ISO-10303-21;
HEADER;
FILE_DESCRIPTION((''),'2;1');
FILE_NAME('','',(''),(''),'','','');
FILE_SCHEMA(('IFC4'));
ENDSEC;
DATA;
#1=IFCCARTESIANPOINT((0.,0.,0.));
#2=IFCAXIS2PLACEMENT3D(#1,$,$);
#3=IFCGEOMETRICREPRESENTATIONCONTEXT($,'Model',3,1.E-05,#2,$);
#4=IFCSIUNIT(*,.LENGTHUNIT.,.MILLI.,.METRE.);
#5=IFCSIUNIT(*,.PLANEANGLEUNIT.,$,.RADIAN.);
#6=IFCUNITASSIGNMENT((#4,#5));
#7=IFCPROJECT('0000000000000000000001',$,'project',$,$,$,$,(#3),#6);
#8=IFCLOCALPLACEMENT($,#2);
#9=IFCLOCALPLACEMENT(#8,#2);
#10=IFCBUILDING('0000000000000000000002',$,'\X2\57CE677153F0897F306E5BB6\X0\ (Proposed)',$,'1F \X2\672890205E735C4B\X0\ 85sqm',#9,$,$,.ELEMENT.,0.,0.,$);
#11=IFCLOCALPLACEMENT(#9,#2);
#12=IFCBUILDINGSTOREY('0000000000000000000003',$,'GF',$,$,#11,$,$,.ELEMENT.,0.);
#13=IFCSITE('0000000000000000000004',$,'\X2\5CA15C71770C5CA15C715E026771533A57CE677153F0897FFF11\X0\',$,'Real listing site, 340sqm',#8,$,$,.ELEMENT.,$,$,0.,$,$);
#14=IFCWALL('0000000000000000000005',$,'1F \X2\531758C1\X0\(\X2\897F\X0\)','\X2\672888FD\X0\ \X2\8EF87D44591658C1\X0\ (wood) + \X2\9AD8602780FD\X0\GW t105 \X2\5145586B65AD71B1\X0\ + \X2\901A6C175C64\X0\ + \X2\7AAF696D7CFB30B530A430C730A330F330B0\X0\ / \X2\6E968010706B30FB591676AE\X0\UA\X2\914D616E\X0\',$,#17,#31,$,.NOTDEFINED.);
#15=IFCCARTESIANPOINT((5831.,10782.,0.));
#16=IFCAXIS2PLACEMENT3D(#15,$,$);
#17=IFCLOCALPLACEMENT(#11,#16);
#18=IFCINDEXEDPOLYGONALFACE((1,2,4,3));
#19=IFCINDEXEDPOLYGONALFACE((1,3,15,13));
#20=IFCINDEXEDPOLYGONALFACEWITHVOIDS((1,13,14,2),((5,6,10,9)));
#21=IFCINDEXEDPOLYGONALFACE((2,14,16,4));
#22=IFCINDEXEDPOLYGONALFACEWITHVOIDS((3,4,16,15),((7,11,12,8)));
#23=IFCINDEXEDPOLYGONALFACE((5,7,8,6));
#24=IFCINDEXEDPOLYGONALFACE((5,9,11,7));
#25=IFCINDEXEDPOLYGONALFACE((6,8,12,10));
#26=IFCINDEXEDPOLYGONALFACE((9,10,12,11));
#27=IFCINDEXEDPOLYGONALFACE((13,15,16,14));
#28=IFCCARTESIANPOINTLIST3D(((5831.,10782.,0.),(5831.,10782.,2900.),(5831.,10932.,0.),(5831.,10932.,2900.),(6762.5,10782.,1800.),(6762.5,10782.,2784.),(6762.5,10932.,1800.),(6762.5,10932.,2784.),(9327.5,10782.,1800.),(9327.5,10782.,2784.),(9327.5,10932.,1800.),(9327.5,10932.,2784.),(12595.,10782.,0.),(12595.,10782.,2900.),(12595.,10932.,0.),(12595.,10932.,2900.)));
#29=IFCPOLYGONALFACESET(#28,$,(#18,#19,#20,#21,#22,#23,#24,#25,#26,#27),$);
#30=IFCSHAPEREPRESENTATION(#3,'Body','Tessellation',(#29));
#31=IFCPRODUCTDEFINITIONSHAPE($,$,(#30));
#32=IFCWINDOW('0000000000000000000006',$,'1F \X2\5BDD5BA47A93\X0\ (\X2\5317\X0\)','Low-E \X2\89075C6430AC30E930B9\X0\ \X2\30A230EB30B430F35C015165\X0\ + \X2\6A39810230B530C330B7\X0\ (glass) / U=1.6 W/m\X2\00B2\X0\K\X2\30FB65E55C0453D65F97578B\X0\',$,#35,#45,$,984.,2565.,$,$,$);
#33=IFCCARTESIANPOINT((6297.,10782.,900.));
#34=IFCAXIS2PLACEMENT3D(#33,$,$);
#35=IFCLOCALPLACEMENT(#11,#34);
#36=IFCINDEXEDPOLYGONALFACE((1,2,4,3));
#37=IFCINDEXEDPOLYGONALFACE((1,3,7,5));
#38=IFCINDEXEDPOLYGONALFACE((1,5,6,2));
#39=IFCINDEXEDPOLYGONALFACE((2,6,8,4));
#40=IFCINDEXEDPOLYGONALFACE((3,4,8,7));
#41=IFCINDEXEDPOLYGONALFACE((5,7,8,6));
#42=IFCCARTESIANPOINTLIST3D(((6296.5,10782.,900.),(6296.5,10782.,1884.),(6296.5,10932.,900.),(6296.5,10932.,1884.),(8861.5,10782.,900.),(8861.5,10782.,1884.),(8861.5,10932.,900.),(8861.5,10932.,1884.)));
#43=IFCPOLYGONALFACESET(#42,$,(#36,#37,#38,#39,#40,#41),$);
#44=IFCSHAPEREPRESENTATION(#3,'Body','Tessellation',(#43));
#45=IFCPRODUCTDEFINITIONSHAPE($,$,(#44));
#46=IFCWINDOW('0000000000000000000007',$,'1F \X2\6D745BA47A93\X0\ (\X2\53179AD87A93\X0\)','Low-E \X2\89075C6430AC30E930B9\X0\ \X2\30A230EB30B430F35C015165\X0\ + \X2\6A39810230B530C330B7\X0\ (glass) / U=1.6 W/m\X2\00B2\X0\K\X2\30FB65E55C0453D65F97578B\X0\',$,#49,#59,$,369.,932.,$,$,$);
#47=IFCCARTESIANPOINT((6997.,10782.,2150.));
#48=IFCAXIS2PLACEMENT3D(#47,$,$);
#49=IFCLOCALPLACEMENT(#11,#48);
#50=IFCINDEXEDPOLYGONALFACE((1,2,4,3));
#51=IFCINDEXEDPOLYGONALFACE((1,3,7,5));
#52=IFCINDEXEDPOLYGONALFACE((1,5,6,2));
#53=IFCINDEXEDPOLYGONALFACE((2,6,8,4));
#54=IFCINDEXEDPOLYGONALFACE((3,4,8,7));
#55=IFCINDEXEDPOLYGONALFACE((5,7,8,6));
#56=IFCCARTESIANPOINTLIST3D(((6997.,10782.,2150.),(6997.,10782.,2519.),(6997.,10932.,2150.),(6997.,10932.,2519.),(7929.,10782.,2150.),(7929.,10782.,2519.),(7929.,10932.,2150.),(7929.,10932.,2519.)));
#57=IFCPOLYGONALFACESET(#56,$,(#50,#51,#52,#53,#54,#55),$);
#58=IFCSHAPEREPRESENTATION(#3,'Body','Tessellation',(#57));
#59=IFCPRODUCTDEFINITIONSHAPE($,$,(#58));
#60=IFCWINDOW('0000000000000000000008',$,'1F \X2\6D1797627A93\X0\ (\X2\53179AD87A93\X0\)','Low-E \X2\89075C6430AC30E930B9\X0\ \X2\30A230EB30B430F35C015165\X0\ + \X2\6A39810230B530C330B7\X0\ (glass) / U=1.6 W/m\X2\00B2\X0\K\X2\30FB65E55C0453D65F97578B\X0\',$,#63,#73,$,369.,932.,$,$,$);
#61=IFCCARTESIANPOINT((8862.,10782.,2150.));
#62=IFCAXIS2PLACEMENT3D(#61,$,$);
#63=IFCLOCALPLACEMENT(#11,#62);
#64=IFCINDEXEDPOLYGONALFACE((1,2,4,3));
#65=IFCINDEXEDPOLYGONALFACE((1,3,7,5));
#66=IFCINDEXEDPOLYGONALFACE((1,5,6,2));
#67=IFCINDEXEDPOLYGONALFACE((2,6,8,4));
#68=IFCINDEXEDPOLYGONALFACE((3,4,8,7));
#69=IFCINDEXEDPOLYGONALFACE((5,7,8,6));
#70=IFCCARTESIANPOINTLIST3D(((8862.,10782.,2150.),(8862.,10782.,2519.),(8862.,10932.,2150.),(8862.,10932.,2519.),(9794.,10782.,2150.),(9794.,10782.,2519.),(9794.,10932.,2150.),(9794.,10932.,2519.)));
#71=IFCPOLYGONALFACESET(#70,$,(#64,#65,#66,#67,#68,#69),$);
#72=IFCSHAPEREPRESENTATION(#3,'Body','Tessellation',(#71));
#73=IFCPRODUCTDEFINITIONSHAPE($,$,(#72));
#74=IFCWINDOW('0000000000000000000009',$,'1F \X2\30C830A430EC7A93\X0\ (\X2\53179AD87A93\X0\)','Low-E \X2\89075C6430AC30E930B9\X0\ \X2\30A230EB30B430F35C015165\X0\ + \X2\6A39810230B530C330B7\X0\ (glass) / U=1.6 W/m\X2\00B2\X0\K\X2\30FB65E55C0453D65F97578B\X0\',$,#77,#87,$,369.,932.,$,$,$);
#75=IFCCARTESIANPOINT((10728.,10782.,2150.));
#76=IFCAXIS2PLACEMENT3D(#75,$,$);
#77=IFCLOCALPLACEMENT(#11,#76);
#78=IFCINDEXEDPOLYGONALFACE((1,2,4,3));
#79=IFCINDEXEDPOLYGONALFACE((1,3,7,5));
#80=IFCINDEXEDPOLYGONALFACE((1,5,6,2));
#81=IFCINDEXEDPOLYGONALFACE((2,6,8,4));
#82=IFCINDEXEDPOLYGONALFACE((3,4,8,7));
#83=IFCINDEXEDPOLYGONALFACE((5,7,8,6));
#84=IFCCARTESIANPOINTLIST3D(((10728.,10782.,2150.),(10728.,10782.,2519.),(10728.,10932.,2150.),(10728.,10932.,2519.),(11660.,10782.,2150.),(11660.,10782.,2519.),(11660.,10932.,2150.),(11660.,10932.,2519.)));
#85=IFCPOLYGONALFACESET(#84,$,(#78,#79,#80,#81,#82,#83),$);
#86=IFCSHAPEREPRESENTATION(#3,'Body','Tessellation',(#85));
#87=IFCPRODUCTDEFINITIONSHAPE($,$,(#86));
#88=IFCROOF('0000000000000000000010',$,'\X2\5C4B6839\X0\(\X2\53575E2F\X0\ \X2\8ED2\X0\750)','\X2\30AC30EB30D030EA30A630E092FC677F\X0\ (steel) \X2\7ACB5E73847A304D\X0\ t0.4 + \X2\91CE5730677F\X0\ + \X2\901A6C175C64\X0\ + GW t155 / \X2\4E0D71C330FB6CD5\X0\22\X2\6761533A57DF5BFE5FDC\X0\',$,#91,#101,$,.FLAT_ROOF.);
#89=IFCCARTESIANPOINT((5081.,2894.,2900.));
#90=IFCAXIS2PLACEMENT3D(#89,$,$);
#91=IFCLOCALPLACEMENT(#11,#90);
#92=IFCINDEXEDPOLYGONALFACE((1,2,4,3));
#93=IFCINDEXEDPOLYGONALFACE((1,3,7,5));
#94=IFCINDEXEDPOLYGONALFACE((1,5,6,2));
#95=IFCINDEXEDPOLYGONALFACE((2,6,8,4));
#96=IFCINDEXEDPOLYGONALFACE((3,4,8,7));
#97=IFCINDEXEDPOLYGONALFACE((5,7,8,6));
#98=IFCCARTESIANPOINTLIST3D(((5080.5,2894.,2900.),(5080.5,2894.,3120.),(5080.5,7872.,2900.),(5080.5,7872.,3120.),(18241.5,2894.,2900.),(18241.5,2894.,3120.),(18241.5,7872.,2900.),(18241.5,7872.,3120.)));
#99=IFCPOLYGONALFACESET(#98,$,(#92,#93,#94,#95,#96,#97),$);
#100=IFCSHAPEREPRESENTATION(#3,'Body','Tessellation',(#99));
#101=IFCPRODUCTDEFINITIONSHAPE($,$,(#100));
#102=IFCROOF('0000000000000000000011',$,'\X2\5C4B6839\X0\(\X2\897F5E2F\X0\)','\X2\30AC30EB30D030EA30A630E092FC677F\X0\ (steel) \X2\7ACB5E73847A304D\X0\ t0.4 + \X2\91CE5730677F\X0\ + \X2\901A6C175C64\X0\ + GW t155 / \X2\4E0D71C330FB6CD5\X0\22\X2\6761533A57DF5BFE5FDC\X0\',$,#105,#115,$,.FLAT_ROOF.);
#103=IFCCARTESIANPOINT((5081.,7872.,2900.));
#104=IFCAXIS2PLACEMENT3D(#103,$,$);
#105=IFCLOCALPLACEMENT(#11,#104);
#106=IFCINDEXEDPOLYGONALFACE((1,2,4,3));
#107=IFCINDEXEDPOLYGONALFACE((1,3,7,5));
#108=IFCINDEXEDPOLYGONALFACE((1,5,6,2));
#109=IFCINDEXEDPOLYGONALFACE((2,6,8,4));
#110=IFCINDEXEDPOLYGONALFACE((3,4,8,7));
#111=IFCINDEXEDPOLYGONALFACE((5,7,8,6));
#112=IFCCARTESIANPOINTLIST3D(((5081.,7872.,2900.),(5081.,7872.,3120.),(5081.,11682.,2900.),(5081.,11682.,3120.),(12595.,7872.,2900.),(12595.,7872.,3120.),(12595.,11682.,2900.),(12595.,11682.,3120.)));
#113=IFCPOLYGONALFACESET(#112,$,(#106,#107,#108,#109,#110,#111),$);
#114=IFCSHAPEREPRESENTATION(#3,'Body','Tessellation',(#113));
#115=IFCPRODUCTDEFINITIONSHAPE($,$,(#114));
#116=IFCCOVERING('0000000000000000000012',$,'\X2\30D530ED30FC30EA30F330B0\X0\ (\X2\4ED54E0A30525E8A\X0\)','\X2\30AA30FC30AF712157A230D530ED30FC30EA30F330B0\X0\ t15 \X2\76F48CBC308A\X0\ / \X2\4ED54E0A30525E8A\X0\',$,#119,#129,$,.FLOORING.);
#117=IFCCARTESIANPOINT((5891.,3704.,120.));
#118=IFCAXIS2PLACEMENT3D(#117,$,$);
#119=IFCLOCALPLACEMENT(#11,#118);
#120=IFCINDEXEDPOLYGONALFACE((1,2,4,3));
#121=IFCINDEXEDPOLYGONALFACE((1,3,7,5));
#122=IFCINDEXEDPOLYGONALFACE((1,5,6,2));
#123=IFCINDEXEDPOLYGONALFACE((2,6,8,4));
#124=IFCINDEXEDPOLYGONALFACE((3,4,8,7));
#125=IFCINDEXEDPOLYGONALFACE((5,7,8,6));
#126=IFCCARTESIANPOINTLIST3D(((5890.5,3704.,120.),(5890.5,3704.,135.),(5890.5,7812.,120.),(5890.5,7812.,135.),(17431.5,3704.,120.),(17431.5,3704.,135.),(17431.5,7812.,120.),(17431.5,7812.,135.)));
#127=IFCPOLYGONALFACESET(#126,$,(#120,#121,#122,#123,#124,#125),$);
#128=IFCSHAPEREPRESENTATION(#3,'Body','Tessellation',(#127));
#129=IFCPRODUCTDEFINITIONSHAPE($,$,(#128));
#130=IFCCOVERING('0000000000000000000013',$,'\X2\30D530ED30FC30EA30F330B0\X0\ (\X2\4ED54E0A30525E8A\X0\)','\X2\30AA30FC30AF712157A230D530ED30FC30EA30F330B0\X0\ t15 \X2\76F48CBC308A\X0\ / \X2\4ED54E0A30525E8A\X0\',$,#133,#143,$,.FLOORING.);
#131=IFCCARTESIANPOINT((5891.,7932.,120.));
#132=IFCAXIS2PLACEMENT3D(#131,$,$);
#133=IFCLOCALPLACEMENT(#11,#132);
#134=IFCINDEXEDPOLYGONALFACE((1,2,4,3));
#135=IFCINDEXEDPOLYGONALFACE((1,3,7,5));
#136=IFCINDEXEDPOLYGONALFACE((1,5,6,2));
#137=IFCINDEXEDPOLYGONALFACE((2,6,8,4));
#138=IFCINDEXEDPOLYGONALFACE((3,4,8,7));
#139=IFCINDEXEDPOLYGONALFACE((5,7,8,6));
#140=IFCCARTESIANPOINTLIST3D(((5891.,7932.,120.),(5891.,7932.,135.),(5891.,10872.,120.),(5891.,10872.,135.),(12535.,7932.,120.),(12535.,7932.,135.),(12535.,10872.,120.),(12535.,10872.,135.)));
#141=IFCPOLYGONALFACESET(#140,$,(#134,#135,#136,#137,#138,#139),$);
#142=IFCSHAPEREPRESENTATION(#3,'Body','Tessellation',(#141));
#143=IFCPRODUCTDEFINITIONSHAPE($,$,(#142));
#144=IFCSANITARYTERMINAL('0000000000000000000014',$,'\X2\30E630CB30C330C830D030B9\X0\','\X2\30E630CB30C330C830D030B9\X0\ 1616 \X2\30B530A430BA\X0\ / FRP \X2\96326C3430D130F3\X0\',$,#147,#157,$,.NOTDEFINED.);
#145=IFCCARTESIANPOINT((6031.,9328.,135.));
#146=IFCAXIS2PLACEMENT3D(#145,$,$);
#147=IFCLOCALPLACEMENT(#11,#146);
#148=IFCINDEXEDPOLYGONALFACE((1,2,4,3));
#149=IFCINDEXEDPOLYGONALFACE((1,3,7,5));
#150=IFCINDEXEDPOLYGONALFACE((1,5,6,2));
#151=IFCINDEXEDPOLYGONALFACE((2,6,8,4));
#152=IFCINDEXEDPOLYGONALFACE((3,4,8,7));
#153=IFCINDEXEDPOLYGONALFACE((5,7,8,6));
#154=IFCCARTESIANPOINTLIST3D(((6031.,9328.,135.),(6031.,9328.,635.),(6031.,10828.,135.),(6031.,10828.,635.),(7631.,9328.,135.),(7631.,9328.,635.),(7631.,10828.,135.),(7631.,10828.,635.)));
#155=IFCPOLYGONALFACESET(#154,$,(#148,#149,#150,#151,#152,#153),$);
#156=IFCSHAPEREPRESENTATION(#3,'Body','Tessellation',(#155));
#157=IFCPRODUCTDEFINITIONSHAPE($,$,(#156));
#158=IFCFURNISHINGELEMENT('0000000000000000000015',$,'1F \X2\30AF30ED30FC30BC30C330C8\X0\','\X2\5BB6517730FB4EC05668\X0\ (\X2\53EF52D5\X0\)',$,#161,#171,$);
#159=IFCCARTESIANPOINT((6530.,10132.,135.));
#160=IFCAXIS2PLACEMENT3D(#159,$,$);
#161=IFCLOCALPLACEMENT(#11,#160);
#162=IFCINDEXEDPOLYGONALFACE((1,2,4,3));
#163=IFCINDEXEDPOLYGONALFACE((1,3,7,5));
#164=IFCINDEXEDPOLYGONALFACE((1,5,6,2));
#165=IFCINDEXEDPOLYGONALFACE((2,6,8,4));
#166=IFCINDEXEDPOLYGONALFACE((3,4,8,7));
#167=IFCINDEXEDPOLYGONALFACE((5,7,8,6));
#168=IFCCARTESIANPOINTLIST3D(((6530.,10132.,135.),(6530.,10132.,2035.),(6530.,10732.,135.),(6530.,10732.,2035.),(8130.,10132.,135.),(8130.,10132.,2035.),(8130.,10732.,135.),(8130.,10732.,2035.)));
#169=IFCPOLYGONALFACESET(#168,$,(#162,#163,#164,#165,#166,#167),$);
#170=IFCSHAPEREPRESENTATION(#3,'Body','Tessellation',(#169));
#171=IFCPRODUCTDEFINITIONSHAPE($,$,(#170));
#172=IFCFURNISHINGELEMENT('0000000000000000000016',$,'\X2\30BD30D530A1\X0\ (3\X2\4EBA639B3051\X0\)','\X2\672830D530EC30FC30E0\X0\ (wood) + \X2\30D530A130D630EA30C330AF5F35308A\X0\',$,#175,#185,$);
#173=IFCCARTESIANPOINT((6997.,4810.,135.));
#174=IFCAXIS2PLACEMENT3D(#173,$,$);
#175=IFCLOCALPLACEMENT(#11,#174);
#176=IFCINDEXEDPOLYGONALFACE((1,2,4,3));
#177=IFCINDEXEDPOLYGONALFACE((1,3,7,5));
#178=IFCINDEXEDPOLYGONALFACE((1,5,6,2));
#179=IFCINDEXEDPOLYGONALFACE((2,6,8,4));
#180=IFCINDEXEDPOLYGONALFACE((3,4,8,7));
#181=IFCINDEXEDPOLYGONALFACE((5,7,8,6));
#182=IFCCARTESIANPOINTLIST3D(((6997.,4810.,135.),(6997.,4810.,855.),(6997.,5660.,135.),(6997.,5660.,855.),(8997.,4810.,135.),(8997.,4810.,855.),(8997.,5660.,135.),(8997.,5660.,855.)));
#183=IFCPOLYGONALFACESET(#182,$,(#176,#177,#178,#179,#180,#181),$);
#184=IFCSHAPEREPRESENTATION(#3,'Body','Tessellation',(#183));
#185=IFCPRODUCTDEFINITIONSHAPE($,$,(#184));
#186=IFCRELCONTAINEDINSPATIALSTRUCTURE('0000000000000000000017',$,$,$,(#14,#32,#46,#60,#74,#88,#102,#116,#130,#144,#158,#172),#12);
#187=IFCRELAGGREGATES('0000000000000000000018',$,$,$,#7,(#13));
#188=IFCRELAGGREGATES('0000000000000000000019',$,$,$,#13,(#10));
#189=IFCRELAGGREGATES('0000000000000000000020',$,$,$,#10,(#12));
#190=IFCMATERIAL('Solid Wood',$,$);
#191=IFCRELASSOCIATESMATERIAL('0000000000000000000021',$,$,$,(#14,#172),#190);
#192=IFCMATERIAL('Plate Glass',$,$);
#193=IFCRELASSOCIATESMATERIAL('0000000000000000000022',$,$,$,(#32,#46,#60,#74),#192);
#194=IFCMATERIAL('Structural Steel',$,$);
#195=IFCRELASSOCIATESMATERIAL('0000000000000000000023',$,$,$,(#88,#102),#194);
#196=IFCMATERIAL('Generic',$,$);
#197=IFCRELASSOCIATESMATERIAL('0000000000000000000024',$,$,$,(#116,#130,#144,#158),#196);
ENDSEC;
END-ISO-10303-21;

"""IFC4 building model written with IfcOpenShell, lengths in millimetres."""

from ifc_helpers import new_model, si_unit, frame, frame_2d, origin, place, context, project, spatial, rectangle, extrude, material, element, fill, save


model = new_model("IFC4")

# Units and contexts
model_context = context("Model", 3, precision=1e-05, world=origin())
ifc_project = project(units=[si_unit("LENGTHUNIT", "METRE", prefix="MILLI"), si_unit("PLANEANGLEUNIT", "RADIAN")], contexts=[model_context])

# Site, building, storey
site_placement = place(None, origin())
site = spatial("IfcSite", under=ifc_project, at=site_placement, Name="岡山県岡山市東区城東台西１", ObjectType="Real listing site, 340sqm", CompositionType="ELEMENT", RefElevation=0.0)
building_placement = place(site_placement, origin())
building = spatial("IfcBuilding", under=site, at=building_placement, Name="城東台西の家 (Proposed)", ObjectType="1F 木造平屋 85sqm", CompositionType="ELEMENT", ElevationOfRefHeight=0.0, ElevationOfTerrain=0.0)
storey_placement = place(building_placement, origin())
storey = spatial("IfcBuildingStorey", under=building, at=storey_placement, Name="GF", CompositionType="ELEMENT", Elevation=0.0)

# Shared definitions
ifc_material_1 = material(Name="Solid Wood")

# Shared definitions
ifc_material_2 = material(Name="Plate Glass")

# Wall, openings, windows
wall_1_placement = place(storey_placement, frame((5831.0, 10782.0, 0.0)))
wall_1 = element("IfcWall", 1, at=wall_1_placement, inside=storey, material=ifc_material_1, Name="1F 北壁(西)", Description="木製 軸組外壁 (wood) + 高性能GW t105 充填断熱 + 通気層 + 窯業系サイディング / 準耐火・外皮UA配慮", PredefinedType="NOTDEFINED", context=model_context, shape_type="SweptSolid", body=[
    extrude(rectangle(XDim=6764.0, YDim=150.0, at=frame_2d((3382.0, 75.0))), frame((5831.0, 10782.0, 0.0)), (0.0, 0.0, 1.0), 2900.0),
])
opening_1_placement = place(storey_placement, frame((6297.0, 10782.0, 900.0)))
opening_1 = element("IfcOpeningElement", 2, at=opening_1_placement, cuts=wall_1, PredefinedType="NOTDEFINED", context=model_context, shape_type="SweptSolid", body=[
    extrude(rectangle(XDim=2565.0, YDim=150.0, at=frame_2d((1282.0, 75.0))), frame((6297.0, 10782.0, 900.0)), (0.0, 0.0, 1.0), 984.0),
])
opening_2_placement = place(storey_placement, frame((6997.0, 10782.0, 2150.0)))
opening_2 = element("IfcOpeningElement", 3, at=opening_2_placement, cuts=wall_1, PredefinedType="NOTDEFINED", context=model_context, shape_type="SweptSolid", body=[
    extrude(rectangle(XDim=932.0, YDim=150.0, at=frame_2d((466.0, 75.0))), frame((6997.0, 10782.0, 2150.0)), (0.0, 0.0, 1.0), 369.0),
])
opening_3_placement = place(storey_placement, frame((8862.0, 10782.0, 2150.0)))
opening_3 = element("IfcOpeningElement", 4, at=opening_3_placement, cuts=wall_1, PredefinedType="NOTDEFINED", context=model_context, shape_type="SweptSolid", body=[
    extrude(rectangle(XDim=932.0, YDim=150.0, at=frame_2d((466.0, 75.0))), frame((8862.0, 10782.0, 2150.0)), (0.0, 0.0, 1.0), 369.0),
])
opening_4_placement = place(storey_placement, frame((10728.0, 10782.0, 2150.0)))
opening_4 = element("IfcOpeningElement", 5, at=opening_4_placement, cuts=wall_1, PredefinedType="NOTDEFINED", context=model_context, shape_type="SweptSolid", body=[
    extrude(rectangle(XDim=932.0, YDim=150.0, at=frame_2d((466.0, 75.0))), frame((10728.0, 10782.0, 2150.0)), (0.0, 0.0, 1.0), 369.0),
])
window_1_placement = place(storey_placement, frame((6297.0, 10782.0, 900.0)))
window_1 = element("IfcWindow", 6, at=window_1_placement, inside=storey, material=ifc_material_2, Name="1F 寝室窓 (北)", Description="Low-E 複層ガラス アルゴン封入 + 樹脂サッシ (glass) / U=1.6 W/m²K・日射取得型", OverallHeight=984.0, OverallWidth=2565.0, context=model_context, shape_type="SweptSolid", body=[
    extrude(rectangle(XDim=2565.0, YDim=150.0, at=frame_2d((1282.0, 75.0))), frame((6297.0, 10782.0, 900.0)), (0.0, 0.0, 1.0), 984.0),
])
fill(opening_1, window_1)
window_2_placement = place(storey_placement, frame((6997.0, 10782.0, 2150.0)))
window_2 = element("IfcWindow", 7, at=window_2_placement, inside=storey, material=ifc_material_2, Name="1F 浴室窓 (北高窓)", Description="Low-E 複層ガラス アルゴン封入 + 樹脂サッシ (glass) / U=1.6 W/m²K・日射取得型", OverallHeight=369.0, OverallWidth=932.0, context=model_context, shape_type="SweptSolid", body=[
    extrude(rectangle(XDim=932.0, YDim=150.0, at=frame_2d((466.0, 75.0))), frame((6997.0, 10782.0, 2150.0)), (0.0, 0.0, 1.0), 369.0),
])
fill(opening_2, window_2)
window_3_placement = place(storey_placement, frame((8862.0, 10782.0, 2150.0)))
window_3 = element("IfcWindow", 8, at=window_3_placement, inside=storey, material=ifc_material_2, Name="1F 洗面窓 (北高窓)", Description="Low-E 複層ガラス アルゴン封入 + 樹脂サッシ (glass) / U=1.6 W/m²K・日射取得型", OverallHeight=369.0, OverallWidth=932.0, context=model_context, shape_type="SweptSolid", body=[
    extrude(rectangle(XDim=932.0, YDim=150.0, at=frame_2d((466.0, 75.0))), frame((8862.0, 10782.0, 2150.0)), (0.0, 0.0, 1.0), 369.0),
])
fill(opening_3, window_3)
window_4_placement = place(storey_placement, frame((10728.0, 10782.0, 2150.0)))
window_4 = element("IfcWindow", 9, at=window_4_placement, inside=storey, material=ifc_material_2, Name="1F トイレ窓 (北高窓)", Description="Low-E 複層ガラス アルゴン封入 + 樹脂サッシ (glass) / U=1.6 W/m²K・日射取得型", OverallHeight=369.0, OverallWidth=932.0, context=model_context, shape_type="SweptSolid", body=[
    extrude(rectangle(XDim=932.0, YDim=150.0, at=frame_2d((466.0, 75.0))), frame((10728.0, 10782.0, 2150.0)), (0.0, 0.0, 1.0), 369.0),
])
fill(opening_4, window_4)

# Roofs
ifc_material_3 = material(Name="Structural Steel")
roof_1_placement = place(storey_placement, frame((5081.0, 2894.0, 2900.0)))
element("IfcRoof", 10, at=roof_1_placement, inside=storey, material=ifc_material_3, Name="屋根(南帯 軒750)", Description="ガルバリウム鋼板 (steel) 立平葺き t0.4 + 野地板 + 通気層 + GW t155 / 不燃・法22条区域対応", PredefinedType="FLAT_ROOF", context=model_context, shape_type="SweptSolid", body=[
    extrude(rectangle(XDim=13161.0, YDim=4978.0, at=frame_2d((6580.0, 2489.0))), frame((5081.0, 2894.0, 2900.0)), (0.0, 0.0, 1.0), 220.0),
])
roof_2_placement = place(storey_placement, frame((5081.0, 7872.0, 2900.0)))
element("IfcRoof", 11, at=roof_2_placement, inside=storey, material=ifc_material_3, Name="屋根(西帯)", Description="ガルバリウム鋼板 (steel) 立平葺き t0.4 + 野地板 + 通気層 + GW t155 / 不燃・法22条区域対応", PredefinedType="FLAT_ROOF", context=model_context, shape_type="SweptSolid", body=[
    extrude(rectangle(XDim=7514.0, YDim=3810.0, at=frame_2d((3757.0, 1905.0))), frame((5081.0, 7872.0, 2900.0)), (0.0, 0.0, 1.0), 220.0),
])

# Coverings
ifc_material_4 = material(Name="Generic")
covering_1_placement = place(storey_placement, frame((5891.0, 3704.0, 120.0)))
element("IfcCovering", 12, at=covering_1_placement, inside=storey, material=ifc_material_4, Name="フローリング (仕上げ床)", Description="オーク無垢フローリング t15 直貼り / 仕上げ床", PredefinedType="FLOORING", context=model_context, shape_type="SweptSolid", body=[
    extrude(rectangle(XDim=11541.0, YDim=4108.0, at=frame_2d((5770.0, 2054.0))), frame((5891.0, 3704.0, 120.0)), (0.0, 0.0, 1.0), 15.0),
])
covering_2_placement = place(storey_placement, frame((5891.0, 7932.0, 120.0)))
element("IfcCovering", 13, at=covering_2_placement, inside=storey, material=ifc_material_4, Name="フローリング (仕上げ床)", Description="オーク無垢フローリング t15 直貼り / 仕上げ床", PredefinedType="FLOORING", context=model_context, shape_type="SweptSolid", body=[
    extrude(rectangle(XDim=6644.0, YDim=2940.0, at=frame_2d((3322.0, 1470.0))), frame((5891.0, 7932.0, 120.0)), (0.0, 0.0, 1.0), 15.0),
])

# Sanitary terminal
sanitary_terminal_placement = place(storey_placement, frame((6031.0, 9328.0, 135.0)))
element("IfcSanitaryTerminal", 14, at=sanitary_terminal_placement, inside=storey, material=ifc_material_4, Name="ユニットバス", Description="ユニットバス 1616 サイズ / FRP 防水パン", PredefinedType="NOTDEFINED", context=model_context, shape_type="SweptSolid", body=[
    extrude(rectangle(XDim=1600.0, YDim=1500.0, at=frame_2d((800.0, 750.0))), frame((6031.0, 9328.0, 135.0)), (0.0, 0.0, 1.0), 500.0),
])

# Furnishing elements
furnishing_1_placement = place(storey_placement, frame((6530.0, 10132.0, 135.0)))
element("IfcFurnishingElement", 15, at=furnishing_1_placement, inside=storey, material=ifc_material_4, Name="1F クローゼット", Description="家具・什器 (可動)", context=model_context, shape_type="SweptSolid", body=[
    extrude(rectangle(XDim=1600.0, YDim=600.0, at=frame_2d((800.0, 300.0))), frame((6530.0, 10132.0, 135.0)), (0.0, 0.0, 1.0), 1900.0),
])
furnishing_2_placement = place(storey_placement, frame((6997.0, 4810.0, 135.0)))
element("IfcFurnishingElement", 16, at=furnishing_2_placement, inside=storey, material=ifc_material_1, Name="ソファ (3人掛け)", Description="木フレーム (wood) + ファブリック張り", context=model_context, shape_type="SweptSolid", body=[
    extrude(rectangle(XDim=2000.0, YDim=850.0, at=frame_2d((1000.0, 425.0))), frame((6997.0, 4810.0, 135.0)), (0.0, 0.0, 1.0), 720.0),
])

save(model, "model.ifc")
